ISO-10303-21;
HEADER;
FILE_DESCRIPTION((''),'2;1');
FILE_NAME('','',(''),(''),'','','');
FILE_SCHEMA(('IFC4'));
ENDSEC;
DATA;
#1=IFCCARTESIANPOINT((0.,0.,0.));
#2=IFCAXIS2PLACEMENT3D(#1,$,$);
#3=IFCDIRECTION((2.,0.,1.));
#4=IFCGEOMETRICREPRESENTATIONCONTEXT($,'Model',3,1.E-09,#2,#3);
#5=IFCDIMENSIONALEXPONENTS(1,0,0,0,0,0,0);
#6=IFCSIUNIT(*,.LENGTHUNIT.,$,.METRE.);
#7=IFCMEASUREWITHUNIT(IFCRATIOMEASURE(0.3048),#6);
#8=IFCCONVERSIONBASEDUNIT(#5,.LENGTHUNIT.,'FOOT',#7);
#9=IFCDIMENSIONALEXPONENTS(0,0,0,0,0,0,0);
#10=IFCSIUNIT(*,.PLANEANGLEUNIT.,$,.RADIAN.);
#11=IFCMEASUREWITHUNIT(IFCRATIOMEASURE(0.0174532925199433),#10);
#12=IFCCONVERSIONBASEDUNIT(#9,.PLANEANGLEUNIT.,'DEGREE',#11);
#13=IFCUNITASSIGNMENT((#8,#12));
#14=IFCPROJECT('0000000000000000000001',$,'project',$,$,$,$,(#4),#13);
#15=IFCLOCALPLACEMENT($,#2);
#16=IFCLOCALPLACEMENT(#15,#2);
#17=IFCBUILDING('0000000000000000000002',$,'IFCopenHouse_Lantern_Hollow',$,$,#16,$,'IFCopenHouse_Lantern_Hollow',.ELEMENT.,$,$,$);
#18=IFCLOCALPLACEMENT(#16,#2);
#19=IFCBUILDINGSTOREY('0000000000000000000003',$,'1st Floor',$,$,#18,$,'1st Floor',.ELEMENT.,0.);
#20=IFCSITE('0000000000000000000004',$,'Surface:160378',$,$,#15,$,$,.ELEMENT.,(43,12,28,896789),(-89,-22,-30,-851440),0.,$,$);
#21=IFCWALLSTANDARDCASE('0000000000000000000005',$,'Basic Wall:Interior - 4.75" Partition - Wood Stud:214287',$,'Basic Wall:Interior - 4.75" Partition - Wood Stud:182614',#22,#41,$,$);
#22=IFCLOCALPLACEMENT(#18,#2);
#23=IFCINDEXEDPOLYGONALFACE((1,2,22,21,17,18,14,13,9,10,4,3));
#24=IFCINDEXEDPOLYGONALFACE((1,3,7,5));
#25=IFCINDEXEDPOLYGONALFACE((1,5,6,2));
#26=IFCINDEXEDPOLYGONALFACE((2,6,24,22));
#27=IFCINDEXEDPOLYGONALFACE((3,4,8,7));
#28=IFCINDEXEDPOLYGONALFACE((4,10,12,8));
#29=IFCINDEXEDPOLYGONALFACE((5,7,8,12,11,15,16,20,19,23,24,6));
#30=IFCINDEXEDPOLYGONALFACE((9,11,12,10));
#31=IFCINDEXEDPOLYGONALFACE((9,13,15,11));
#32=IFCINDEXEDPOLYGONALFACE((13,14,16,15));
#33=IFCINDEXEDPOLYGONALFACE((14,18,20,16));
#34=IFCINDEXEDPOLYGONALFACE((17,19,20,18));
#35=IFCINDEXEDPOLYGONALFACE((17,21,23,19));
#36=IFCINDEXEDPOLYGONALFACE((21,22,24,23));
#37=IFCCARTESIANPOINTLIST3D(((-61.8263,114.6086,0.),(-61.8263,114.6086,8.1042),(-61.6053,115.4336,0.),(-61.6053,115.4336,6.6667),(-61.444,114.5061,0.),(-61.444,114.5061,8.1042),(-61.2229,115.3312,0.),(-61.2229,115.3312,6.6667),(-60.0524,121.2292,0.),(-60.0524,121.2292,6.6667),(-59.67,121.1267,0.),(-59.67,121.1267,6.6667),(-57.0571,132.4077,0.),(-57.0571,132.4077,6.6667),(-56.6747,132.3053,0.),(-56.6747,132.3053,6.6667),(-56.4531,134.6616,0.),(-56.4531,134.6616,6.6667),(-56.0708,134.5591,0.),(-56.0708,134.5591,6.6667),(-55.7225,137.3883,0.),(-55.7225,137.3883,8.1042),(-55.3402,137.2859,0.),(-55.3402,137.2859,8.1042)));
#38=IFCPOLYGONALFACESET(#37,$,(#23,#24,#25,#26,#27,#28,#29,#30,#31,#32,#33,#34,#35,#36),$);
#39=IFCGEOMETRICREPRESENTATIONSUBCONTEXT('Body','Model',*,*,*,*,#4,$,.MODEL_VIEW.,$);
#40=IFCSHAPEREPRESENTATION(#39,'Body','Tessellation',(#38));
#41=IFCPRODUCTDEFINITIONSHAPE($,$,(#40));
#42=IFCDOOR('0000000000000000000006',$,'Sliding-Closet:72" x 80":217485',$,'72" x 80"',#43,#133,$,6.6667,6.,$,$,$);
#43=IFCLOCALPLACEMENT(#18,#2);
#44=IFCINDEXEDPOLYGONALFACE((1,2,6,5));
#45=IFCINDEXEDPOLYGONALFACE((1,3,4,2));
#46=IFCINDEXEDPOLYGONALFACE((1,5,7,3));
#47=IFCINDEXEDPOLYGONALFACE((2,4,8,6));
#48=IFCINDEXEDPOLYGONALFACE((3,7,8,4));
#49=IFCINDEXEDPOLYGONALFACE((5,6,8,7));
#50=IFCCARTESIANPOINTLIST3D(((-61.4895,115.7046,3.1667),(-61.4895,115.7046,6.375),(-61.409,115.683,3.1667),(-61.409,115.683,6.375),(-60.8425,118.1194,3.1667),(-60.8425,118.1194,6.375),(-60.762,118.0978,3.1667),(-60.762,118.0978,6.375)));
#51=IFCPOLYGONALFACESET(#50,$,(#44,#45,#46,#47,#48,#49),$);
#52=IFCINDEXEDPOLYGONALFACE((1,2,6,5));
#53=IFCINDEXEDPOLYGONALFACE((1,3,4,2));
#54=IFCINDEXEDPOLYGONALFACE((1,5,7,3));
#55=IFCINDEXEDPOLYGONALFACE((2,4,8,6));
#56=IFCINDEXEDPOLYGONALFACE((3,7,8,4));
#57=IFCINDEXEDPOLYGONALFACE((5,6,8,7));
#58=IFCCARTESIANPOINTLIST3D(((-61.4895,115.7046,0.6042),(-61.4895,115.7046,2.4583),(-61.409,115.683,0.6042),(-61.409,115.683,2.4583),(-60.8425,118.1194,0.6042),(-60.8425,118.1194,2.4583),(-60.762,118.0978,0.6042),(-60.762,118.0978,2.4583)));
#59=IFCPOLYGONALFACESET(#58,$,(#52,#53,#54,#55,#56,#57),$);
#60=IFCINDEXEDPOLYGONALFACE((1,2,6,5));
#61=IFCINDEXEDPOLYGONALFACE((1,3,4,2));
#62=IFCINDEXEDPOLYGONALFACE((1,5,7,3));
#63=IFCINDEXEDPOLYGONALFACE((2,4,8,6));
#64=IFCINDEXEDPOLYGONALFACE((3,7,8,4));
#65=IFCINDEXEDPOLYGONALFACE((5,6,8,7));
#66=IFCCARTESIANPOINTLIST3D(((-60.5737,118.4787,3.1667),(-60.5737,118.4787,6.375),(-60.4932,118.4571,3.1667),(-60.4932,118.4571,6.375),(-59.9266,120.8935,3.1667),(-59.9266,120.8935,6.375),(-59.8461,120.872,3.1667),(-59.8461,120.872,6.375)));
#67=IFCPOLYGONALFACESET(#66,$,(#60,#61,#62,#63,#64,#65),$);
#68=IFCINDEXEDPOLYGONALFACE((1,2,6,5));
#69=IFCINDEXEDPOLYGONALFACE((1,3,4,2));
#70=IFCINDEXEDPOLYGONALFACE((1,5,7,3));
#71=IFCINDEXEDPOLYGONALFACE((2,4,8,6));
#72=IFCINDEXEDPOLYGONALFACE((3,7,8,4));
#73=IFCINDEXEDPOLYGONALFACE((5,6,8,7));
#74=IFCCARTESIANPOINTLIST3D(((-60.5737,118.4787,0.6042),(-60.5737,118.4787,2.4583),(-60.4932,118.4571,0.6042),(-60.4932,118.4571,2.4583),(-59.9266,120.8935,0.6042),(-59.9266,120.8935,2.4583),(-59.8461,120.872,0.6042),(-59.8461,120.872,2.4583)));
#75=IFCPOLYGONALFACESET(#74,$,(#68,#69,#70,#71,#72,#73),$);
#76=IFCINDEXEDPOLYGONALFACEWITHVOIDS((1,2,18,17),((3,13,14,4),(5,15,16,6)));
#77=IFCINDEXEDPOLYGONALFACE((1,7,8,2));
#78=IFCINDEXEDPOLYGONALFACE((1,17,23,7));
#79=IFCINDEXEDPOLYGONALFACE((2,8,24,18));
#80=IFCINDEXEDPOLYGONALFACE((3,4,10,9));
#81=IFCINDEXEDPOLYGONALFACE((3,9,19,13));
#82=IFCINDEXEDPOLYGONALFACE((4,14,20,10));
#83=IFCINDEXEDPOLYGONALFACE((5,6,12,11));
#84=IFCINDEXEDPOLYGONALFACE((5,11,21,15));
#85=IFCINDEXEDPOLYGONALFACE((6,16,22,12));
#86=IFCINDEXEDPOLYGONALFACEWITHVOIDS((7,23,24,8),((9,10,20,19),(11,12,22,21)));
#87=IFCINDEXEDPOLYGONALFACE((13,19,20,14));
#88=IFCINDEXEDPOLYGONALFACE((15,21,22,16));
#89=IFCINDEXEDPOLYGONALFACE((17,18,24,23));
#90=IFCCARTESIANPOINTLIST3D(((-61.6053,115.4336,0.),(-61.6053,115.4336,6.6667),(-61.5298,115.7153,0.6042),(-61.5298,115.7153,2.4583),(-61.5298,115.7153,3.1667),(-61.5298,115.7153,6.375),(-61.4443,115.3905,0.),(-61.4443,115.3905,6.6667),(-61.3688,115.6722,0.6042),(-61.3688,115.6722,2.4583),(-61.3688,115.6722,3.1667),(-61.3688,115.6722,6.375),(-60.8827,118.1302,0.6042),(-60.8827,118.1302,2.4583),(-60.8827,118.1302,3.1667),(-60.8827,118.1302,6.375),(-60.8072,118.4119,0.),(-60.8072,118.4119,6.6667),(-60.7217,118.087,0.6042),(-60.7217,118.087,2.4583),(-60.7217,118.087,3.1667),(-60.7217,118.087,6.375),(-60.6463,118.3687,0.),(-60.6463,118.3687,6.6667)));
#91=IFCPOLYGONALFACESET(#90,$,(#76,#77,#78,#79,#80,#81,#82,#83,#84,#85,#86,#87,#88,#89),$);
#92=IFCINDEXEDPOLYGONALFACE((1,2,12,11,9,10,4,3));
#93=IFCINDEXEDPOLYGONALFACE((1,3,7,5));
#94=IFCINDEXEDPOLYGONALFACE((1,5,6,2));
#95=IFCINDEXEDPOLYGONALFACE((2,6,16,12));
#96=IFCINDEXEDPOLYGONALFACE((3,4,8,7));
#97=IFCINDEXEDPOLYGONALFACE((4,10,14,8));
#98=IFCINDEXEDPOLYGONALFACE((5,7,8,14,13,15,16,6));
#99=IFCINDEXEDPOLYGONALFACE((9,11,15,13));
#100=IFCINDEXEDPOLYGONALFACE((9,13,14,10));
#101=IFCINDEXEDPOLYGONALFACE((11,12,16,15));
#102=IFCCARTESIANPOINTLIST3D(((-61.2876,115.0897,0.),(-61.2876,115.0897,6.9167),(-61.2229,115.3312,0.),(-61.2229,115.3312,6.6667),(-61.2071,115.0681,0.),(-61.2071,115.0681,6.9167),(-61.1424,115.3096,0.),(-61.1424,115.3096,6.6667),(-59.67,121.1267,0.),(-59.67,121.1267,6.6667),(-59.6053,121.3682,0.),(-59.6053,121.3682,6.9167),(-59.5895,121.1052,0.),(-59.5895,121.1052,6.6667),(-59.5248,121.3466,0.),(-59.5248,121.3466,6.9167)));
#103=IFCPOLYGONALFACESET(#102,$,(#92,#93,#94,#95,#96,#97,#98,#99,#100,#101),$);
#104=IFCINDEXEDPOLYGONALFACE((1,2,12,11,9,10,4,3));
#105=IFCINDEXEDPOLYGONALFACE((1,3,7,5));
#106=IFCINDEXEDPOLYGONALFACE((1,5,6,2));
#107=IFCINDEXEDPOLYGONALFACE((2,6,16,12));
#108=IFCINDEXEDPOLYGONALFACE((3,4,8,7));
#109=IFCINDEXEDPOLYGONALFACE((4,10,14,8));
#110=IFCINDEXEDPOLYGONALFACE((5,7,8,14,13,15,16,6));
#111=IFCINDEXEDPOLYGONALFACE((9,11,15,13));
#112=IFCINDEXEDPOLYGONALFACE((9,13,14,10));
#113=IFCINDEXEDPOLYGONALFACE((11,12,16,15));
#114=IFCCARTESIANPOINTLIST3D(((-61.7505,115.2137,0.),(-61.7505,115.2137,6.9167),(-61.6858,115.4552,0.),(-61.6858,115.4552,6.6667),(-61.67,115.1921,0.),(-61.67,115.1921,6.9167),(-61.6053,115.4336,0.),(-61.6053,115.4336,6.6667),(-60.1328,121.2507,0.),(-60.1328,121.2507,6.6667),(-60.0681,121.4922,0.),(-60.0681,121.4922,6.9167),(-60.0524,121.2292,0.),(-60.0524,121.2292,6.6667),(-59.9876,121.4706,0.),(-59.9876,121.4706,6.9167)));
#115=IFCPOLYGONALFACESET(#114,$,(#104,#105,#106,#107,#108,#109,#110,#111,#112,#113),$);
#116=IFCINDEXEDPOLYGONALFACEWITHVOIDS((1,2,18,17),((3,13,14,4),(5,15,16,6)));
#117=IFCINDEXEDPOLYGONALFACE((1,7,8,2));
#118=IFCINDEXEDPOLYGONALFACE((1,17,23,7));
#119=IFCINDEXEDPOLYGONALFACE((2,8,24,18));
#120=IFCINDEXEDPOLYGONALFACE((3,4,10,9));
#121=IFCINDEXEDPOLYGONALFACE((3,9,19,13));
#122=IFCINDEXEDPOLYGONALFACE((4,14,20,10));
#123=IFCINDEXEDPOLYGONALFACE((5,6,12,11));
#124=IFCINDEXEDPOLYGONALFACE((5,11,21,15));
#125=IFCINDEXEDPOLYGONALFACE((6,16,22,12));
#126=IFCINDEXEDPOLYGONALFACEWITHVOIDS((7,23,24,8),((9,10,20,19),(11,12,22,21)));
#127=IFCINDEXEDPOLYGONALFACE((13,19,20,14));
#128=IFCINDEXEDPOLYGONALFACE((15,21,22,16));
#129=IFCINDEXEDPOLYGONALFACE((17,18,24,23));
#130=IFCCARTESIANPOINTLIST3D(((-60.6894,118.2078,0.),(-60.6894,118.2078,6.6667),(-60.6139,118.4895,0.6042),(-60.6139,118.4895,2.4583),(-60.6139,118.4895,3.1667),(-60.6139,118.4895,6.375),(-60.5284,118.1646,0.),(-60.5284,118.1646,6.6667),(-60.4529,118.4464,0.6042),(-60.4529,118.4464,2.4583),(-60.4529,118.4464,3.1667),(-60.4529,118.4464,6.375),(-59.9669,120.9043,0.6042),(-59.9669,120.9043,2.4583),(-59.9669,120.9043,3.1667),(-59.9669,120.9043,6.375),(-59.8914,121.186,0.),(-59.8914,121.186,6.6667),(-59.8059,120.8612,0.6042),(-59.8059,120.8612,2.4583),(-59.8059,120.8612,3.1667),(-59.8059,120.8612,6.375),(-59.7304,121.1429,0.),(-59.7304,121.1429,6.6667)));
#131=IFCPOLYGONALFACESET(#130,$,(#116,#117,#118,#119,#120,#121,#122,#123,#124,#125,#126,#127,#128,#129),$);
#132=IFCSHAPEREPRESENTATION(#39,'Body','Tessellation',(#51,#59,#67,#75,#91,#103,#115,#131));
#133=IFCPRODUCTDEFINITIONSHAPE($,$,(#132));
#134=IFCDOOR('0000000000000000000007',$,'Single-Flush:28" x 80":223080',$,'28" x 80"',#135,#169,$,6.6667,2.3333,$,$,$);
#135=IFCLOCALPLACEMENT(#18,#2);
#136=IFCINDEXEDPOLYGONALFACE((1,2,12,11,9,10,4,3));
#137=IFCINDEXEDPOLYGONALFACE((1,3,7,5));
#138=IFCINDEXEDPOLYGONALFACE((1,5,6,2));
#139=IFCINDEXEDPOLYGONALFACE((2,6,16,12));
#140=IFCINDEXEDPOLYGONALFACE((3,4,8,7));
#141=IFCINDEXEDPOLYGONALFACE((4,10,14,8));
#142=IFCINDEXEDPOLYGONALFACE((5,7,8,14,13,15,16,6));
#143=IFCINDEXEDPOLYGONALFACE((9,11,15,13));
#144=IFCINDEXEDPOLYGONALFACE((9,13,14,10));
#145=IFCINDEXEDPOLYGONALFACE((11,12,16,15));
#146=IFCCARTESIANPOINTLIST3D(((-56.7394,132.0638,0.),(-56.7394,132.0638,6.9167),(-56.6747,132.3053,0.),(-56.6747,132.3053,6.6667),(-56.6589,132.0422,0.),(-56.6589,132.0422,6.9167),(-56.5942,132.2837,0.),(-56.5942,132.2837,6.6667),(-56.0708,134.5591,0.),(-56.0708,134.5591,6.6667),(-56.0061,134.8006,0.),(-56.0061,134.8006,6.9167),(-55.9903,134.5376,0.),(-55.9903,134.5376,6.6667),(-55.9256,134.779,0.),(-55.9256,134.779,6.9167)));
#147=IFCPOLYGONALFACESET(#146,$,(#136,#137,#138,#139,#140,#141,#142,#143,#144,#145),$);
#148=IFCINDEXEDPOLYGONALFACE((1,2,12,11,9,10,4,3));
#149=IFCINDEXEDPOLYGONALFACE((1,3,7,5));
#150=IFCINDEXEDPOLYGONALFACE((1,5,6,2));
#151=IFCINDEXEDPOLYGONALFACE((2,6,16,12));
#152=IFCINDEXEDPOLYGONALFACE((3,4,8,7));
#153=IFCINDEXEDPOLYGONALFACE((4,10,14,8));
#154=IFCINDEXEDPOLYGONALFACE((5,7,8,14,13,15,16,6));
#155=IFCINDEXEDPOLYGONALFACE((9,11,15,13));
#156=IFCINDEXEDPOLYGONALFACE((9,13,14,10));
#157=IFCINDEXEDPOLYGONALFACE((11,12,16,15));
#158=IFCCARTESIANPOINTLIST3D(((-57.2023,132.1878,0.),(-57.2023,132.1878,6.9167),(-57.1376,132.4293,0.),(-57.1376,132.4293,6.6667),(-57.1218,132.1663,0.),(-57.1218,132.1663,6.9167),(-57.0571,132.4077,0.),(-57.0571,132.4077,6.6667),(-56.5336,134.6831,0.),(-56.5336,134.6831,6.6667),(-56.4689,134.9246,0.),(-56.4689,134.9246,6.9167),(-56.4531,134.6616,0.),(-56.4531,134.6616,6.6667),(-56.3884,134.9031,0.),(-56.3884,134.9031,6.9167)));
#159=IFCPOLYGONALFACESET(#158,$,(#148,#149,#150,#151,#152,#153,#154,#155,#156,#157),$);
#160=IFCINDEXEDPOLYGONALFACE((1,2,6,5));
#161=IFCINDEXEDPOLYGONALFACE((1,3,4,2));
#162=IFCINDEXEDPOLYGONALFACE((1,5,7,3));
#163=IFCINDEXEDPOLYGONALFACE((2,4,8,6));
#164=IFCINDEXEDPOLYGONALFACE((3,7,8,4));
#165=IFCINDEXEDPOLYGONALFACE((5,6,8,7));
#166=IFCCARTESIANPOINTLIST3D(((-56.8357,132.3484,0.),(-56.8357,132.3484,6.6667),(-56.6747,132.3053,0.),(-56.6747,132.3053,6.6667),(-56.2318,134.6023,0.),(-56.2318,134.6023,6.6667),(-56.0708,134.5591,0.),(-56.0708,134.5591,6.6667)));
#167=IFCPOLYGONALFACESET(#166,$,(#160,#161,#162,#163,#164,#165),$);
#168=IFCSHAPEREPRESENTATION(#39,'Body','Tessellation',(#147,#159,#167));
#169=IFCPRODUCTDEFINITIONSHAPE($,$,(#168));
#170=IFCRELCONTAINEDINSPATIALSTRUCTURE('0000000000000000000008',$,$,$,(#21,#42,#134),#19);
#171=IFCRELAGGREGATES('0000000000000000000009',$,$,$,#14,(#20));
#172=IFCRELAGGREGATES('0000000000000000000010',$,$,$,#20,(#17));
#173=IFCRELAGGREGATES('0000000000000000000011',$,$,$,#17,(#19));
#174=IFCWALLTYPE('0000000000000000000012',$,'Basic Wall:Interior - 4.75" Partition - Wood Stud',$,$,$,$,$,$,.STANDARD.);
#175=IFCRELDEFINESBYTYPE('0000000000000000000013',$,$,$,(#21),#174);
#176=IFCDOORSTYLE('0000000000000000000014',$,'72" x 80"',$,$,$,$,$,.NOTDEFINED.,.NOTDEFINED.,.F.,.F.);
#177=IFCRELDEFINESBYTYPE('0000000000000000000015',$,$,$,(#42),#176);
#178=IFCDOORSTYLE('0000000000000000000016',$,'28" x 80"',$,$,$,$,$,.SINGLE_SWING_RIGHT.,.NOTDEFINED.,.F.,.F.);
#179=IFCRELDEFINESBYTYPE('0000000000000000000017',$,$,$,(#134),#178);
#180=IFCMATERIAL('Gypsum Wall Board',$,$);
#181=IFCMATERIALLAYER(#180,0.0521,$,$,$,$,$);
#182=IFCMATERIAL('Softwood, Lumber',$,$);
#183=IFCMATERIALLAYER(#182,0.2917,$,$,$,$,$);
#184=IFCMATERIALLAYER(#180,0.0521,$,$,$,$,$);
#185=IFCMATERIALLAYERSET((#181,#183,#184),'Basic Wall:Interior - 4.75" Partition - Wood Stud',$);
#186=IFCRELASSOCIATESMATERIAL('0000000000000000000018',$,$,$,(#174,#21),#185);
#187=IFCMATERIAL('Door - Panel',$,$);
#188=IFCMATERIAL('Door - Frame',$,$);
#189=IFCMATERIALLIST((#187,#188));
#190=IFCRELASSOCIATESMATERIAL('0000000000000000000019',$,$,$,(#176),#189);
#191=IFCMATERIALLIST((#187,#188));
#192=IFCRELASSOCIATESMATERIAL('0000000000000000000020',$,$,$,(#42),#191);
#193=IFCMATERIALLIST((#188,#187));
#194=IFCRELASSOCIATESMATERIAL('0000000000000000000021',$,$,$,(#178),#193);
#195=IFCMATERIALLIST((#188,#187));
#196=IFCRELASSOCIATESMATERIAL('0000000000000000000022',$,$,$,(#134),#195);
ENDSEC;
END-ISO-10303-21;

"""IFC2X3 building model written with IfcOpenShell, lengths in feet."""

from ifc_helpers import new_model, entity, si_unit, converted_unit, direction, frame, frame_2d, origin, origin_2d_with_axis, place, context, subcontext, project, spatial, polyline, rectangle, outline, extrude, source, transform, mapped, material, material_list, layer, layer_set, layer_usage, type_object, type_shapes, element, fill, save


model = new_model("IFC2X3")

# Units and contexts
model_context = context("Model", 3, precision=1e-09, world=origin(), true_north=direction((2.0, 0.0, 1.0)))
body_context = subcontext(model_context, "Body", "Model", "MODEL_VIEW")
ifc_project = project(units=[converted_unit("LENGTHUNIT", "FOOT", entity("IfcRatioMeasure", 0.3048), si_unit("LENGTHUNIT", "METRE"), dimensions=[1, 0, 0, 0, 0, 0, 0]), converted_unit("PLANEANGLEUNIT", "DEGREE", entity("IfcRatioMeasure", 0.0174532925199433), si_unit("PLANEANGLEUNIT", "RADIAN"), dimensions=[0, 0, 0, 0, 0, 0, 0])], contexts=[model_context])

# Site, building, storey
site_placement = place(None, origin())
site = spatial("IfcSite", under=ifc_project, at=site_placement, Name="Surface:160378", CompositionType="ELEMENT", RefLatitude=(43, 12, 28, 896789), RefLongitude=(-89, -22, -30, -851440), RefElevation=0.0)
building_placement = place(site_placement, origin())
building = spatial("IfcBuilding", under=site, at=building_placement, Name="IFCopenHouse_Lantern_Hollow", LongName="IFCopenHouse_Lantern_Hollow", CompositionType="ELEMENT")
storey_placement = place(building_placement, origin())
storey = spatial("IfcBuildingStorey", under=building, at=storey_placement, Name="1st Floor", LongName="1st Floor", CompositionType="ELEMENT", Elevation=0.0)

# Shared definitions
ifc_material_1 = material(Name="Softwood, Lumber")
ifc_material_2 = material(Name="Gypsum Wall Board")

# Wall, openings, doors
ifc_layer_1 = layer(ifc_material_2, 0.0521)
ifc_layer_2 = layer(ifc_material_1, 0.2917)
ifc_layer_3 = layer(ifc_material_2, 0.0521)
ifc_layer_set_1 = layer_set([ifc_layer_1, ifc_layer_2, ifc_layer_3], Name="Basic Wall:Interior - 4.75\" Partition - Wood Stud")
ifc_layer_usage_1 = layer_usage(ifc_layer_set_1, "AXIS2", "NEGATIVE", 0.1979)
wall_type = type_object("IfcWallType", Name="Basic Wall:Interior - 4.75\" Partition - Wood Stud", PredefinedType="STANDARD", material=ifc_layer_set_1)
wall_1_placement = place(storey_placement, frame((-61.6352, 114.5573, 0.0), z_axis=(0.0, 0.0, 1.0), x_axis=(0.258819, 0.965926, 0.0)))
wall_1 = element("IfcWallStandardCase", 1, at=wall_1_placement, inside=storey, type_object=wall_type, material=ifc_layer_usage_1, Name="Basic Wall:Interior - 4.75\" Partition - Wood Stud:214287", ObjectType="Basic Wall:Interior - 4.75\" Partition - Wood Stud:182614", context=body_context, shape_type="SweptSolid", body=[
    extrude(rectangle(XDim=23.5833, YDim=0.3958, at=frame_2d((11.7917, 0.0), x_axis=(-1.0, 0.0))), origin(), (0.0, 0.0, 1.0), 8.1042),
])
opening_1_placement = place(wall_1_placement, frame((0.8542, -0.1979, 0.0)))
opening_1 = element("IfcOpeningElement", 2, at=opening_1_placement, cuts=wall_1, ObjectType="Opening", context=body_context, shape_type="SweptSolid", body=[
    extrude(rectangle(XDim=6.6667, YDim=6.0, at=frame_2d((3.3333, 3.0), x_axis=(-1.0, 0.0))), frame((0.0, 0.0, 0.0), z_axis=(0.0, 1.0, 0.0), x_axis=(0.0, 0.0, 1.0)), (0.0, 0.0, 1.0), 0.3958),
])
opening_2_placement = place(wall_1_placement, frame((20.7604, 0.1979, 0.0)))
opening_2 = element("IfcOpeningElement", 3, at=opening_2_placement, cuts=wall_1, ObjectType="Opening", context=body_context, shape_type="SweptSolid", body=[
    extrude(rectangle(XDim=2.3333, YDim=6.6667, at=frame_2d((3.3333, 1.1667), x_axis=(0.0, 1.0))), frame((0.0, 0.0, 0.0), z_axis=(0.0, -1.0, 0.0), x_axis=(0.0, 0.0, 1.0)), (0.0, 0.0, 1.0), 0.3958),
])
ifc_material_3 = material(Name="Door - Panel")
ifc_material_4 = material(Name="Door - Frame")
ifc_material_list_1 = material_list([ifc_material_3, ifc_material_4])
ifc_material_list_2 = material_list([ifc_material_3, ifc_material_4])
door_style_1 = type_object("IfcDoorStyle", Name="72\" x 80\"", ConstructionType="NOTDEFINED", OperationType="NOTDEFINED", ParameterTakesPrecedence=False, Sizeable=False, material=ifc_material_list_2)
shared_shape_1 = source(origin(), body_context, "Body", "SweptSolid", [
    extrude(rectangle(XDim=0.0833, YDim=2.5, at=origin_2d_with_axis()), frame((1.5417, 0.3125, 3.1667), z_axis=(0.0, 0.0, 1.0), x_axis=(0.0, 1.0, 0.0)), (0.0, 0.0, 1.0), 3.2083),
    extrude(rectangle(XDim=0.0833, YDim=2.5, at=origin_2d_with_axis()), frame((1.5417, 0.3125, 0.6042), z_axis=(0.0, 0.0, 1.0), x_axis=(0.0, 1.0, 0.0)), (0.0, 0.0, 1.0), 1.8542),
    extrude(rectangle(XDim=0.0833, YDim=2.5, at=origin_2d_with_axis()), frame((4.4583, 0.1458, 3.1667), z_axis=(0.0, 0.0, 1.0), x_axis=(0.0, -1.0, 0.0)), (0.0, 0.0, 1.0), 3.2083),
    extrude(rectangle(XDim=0.0833, YDim=2.5, at=origin_2d_with_axis()), frame((4.4583, 0.1458, 0.6042), z_axis=(0.0, 0.0, 1.0), x_axis=(0.0, -1.0, 0.0)), (0.0, 0.0, 1.0), 1.8542),
    extrude(outline(polyline([(-3.3333, -1.5417), (3.3333, -1.5417), (3.3333, 1.5417), (-3.3333, 1.5417), (-3.3333, -1.5417)]), holes=[polyline([(2.7292, 1.25), (2.7292, -1.25), (0.875, -1.25), (0.875, 1.25), (2.7292, 1.25)]), polyline([(0.1667, 1.25), (0.1667, -1.25), (-3.0417, -1.25), (-3.0417, 1.25), (0.1667, 1.25)])]), frame((1.5417, 0.2292, 3.3333), z_axis=(0.0, 1.0, 0.0), x_axis=(0.0, 0.0, -1.0)), (0.0, 0.0, 1.0), 0.1667),
    extrude(outline(polyline([(-3.3958, -3.25), (3.5208, -3.25), (3.5208, 3.25), (-3.3958, 3.25), (-3.3958, 3.0), (3.2708, 3.0), (3.2708, -3.0), (-3.3958, -3.0), (-3.3958, -3.25)])), frame((3.0, -0.0833, 3.3958), z_axis=(0.0, 1.0, 0.0), x_axis=(0.0, 0.0, 1.0)), (0.0, 0.0, 1.0), 0.0833),
    extrude(outline(polyline([(-3.25, -3.3958), (-3.0, -3.3958), (-3.0, 3.2708), (3.0, 3.2708), (3.0, -3.3958), (3.25, -3.3958), (3.25, 3.5208), (-3.25, 3.5208), (-3.25, -3.3958)])), frame((3.0, 0.3958, 3.3958), z_axis=(0.0, 1.0, 0.0), x_axis=(-1.0, 0.0, 0.0)), (0.0, 0.0, 1.0), 0.0833),
    extrude(outline(polyline([(-1.5417, -3.3333), (1.5417, -3.3333), (1.5417, 3.3333), (-1.5417, 3.3333), (-1.5417, -3.3333)]), holes=[polyline([(1.25, 0.1667), (1.25, -3.0417), (-1.25, -3.0417), (-1.25, 0.1667), (1.25, 0.1667)]), polyline([(1.25, 2.7292), (1.25, 0.875), (-1.25, 0.875), (-1.25, 2.7292), (1.25, 2.7292)])]), frame((4.4583, 0.0625, 3.3333), z_axis=(0.0, 1.0, 0.0), x_axis=(1.0, 0.0, 0.0)), (0.0, 0.0, 1.0), 0.1667),
])
type_shapes(door_style_1, [shared_shape_1])
door_1_placement = place(opening_1_placement, origin())
door_1 = element("IfcDoor", 4, at=door_1_placement, inside=storey, type_object=door_style_1, material=ifc_material_list_1, Name="Sliding-Closet:72\" x 80\":217485", ObjectType="72\" x 80\"", OverallHeight=6.6667, OverallWidth=6.0, context=body_context, shape_type="MappedRepresentation", body=[
    mapped(shared_shape_1, transform((0.0, 0.0, 0.0), scale=1.0)),
])
fill(opening_1, door_1)
ifc_material_list_3 = material_list([ifc_material_4, ifc_material_3])
ifc_material_list_4 = material_list([ifc_material_4, ifc_material_3])
door_style_2 = type_object("IfcDoorStyle", Name="28\" x 80\"", ConstructionType="NOTDEFINED", OperationType="SINGLE_SWING_RIGHT", ParameterTakesPrecedence=False, Sizeable=False, material=ifc_material_list_4)
shared_shape_2 = source(origin(), body_context, "Body", "SweptSolid", [
    extrude(outline(polyline([(-1.4167, -3.5208), (1.4167, -3.5208), (1.4167, 3.3958), (1.1667, 3.3958), (1.1667, -3.2708), (-1.1667, -3.2708), (-1.1667, 3.3958), (-1.4167, 3.3958), (-1.4167, -3.5208)])), frame((1.1667, 0.3958, 3.3958), z_axis=(0.0, 1.0, 0.0), x_axis=(1.0, 0.0, 0.0)), (0.0, 0.0, 1.0), 0.0833),
    extrude(outline(polyline([(-3.5208, -1.4167), (3.3958, -1.4167), (3.3958, -1.1667), (-3.2708, -1.1667), (-3.2708, 1.1667), (3.3958, 1.1667), (3.3958, 1.4167), (-3.5208, 1.4167), (-3.5208, -1.4167)])), frame((1.1667, -0.0833, 3.3958), z_axis=(0.0, 1.0, 0.0), x_axis=(0.0, 0.0, -1.0)), (0.0, 0.0, 1.0), 0.0833),
    extrude(rectangle(XDim=0.1667, YDim=2.3333, at=frame_2d((0.0, 0.0), x_axis=(1.0, 0.0))), frame((1.1667, 0.3125, 0.0), z_axis=(0.0, 0.0, 1.0), x_axis=(0.0, 1.0, 0.0)), (0.0, 0.0, 1.0), 6.6667),
])
type_shapes(door_style_2, [shared_shape_2])
door_2_placement = place(opening_2_placement, frame((0.0, 0.0, 0.0), z_axis=(0.0, 0.0, 1.0), x_axis=(-1.0, 0.0, 0.0)))
door_2 = element("IfcDoor", 5, at=door_2_placement, inside=storey, type_object=door_style_2, material=ifc_material_list_3, Name="Single-Flush:28\" x 80\":223080", ObjectType="28\" x 80\"", OverallHeight=6.6667, OverallWidth=2.3333, context=body_context, shape_type="MappedRepresentation", body=[
    mapped(shared_shape_2, transform((0.0, 0.0, 0.0), scale=1.0)),
])
fill(opening_2, door_2)

save(model, "model.ifc")
